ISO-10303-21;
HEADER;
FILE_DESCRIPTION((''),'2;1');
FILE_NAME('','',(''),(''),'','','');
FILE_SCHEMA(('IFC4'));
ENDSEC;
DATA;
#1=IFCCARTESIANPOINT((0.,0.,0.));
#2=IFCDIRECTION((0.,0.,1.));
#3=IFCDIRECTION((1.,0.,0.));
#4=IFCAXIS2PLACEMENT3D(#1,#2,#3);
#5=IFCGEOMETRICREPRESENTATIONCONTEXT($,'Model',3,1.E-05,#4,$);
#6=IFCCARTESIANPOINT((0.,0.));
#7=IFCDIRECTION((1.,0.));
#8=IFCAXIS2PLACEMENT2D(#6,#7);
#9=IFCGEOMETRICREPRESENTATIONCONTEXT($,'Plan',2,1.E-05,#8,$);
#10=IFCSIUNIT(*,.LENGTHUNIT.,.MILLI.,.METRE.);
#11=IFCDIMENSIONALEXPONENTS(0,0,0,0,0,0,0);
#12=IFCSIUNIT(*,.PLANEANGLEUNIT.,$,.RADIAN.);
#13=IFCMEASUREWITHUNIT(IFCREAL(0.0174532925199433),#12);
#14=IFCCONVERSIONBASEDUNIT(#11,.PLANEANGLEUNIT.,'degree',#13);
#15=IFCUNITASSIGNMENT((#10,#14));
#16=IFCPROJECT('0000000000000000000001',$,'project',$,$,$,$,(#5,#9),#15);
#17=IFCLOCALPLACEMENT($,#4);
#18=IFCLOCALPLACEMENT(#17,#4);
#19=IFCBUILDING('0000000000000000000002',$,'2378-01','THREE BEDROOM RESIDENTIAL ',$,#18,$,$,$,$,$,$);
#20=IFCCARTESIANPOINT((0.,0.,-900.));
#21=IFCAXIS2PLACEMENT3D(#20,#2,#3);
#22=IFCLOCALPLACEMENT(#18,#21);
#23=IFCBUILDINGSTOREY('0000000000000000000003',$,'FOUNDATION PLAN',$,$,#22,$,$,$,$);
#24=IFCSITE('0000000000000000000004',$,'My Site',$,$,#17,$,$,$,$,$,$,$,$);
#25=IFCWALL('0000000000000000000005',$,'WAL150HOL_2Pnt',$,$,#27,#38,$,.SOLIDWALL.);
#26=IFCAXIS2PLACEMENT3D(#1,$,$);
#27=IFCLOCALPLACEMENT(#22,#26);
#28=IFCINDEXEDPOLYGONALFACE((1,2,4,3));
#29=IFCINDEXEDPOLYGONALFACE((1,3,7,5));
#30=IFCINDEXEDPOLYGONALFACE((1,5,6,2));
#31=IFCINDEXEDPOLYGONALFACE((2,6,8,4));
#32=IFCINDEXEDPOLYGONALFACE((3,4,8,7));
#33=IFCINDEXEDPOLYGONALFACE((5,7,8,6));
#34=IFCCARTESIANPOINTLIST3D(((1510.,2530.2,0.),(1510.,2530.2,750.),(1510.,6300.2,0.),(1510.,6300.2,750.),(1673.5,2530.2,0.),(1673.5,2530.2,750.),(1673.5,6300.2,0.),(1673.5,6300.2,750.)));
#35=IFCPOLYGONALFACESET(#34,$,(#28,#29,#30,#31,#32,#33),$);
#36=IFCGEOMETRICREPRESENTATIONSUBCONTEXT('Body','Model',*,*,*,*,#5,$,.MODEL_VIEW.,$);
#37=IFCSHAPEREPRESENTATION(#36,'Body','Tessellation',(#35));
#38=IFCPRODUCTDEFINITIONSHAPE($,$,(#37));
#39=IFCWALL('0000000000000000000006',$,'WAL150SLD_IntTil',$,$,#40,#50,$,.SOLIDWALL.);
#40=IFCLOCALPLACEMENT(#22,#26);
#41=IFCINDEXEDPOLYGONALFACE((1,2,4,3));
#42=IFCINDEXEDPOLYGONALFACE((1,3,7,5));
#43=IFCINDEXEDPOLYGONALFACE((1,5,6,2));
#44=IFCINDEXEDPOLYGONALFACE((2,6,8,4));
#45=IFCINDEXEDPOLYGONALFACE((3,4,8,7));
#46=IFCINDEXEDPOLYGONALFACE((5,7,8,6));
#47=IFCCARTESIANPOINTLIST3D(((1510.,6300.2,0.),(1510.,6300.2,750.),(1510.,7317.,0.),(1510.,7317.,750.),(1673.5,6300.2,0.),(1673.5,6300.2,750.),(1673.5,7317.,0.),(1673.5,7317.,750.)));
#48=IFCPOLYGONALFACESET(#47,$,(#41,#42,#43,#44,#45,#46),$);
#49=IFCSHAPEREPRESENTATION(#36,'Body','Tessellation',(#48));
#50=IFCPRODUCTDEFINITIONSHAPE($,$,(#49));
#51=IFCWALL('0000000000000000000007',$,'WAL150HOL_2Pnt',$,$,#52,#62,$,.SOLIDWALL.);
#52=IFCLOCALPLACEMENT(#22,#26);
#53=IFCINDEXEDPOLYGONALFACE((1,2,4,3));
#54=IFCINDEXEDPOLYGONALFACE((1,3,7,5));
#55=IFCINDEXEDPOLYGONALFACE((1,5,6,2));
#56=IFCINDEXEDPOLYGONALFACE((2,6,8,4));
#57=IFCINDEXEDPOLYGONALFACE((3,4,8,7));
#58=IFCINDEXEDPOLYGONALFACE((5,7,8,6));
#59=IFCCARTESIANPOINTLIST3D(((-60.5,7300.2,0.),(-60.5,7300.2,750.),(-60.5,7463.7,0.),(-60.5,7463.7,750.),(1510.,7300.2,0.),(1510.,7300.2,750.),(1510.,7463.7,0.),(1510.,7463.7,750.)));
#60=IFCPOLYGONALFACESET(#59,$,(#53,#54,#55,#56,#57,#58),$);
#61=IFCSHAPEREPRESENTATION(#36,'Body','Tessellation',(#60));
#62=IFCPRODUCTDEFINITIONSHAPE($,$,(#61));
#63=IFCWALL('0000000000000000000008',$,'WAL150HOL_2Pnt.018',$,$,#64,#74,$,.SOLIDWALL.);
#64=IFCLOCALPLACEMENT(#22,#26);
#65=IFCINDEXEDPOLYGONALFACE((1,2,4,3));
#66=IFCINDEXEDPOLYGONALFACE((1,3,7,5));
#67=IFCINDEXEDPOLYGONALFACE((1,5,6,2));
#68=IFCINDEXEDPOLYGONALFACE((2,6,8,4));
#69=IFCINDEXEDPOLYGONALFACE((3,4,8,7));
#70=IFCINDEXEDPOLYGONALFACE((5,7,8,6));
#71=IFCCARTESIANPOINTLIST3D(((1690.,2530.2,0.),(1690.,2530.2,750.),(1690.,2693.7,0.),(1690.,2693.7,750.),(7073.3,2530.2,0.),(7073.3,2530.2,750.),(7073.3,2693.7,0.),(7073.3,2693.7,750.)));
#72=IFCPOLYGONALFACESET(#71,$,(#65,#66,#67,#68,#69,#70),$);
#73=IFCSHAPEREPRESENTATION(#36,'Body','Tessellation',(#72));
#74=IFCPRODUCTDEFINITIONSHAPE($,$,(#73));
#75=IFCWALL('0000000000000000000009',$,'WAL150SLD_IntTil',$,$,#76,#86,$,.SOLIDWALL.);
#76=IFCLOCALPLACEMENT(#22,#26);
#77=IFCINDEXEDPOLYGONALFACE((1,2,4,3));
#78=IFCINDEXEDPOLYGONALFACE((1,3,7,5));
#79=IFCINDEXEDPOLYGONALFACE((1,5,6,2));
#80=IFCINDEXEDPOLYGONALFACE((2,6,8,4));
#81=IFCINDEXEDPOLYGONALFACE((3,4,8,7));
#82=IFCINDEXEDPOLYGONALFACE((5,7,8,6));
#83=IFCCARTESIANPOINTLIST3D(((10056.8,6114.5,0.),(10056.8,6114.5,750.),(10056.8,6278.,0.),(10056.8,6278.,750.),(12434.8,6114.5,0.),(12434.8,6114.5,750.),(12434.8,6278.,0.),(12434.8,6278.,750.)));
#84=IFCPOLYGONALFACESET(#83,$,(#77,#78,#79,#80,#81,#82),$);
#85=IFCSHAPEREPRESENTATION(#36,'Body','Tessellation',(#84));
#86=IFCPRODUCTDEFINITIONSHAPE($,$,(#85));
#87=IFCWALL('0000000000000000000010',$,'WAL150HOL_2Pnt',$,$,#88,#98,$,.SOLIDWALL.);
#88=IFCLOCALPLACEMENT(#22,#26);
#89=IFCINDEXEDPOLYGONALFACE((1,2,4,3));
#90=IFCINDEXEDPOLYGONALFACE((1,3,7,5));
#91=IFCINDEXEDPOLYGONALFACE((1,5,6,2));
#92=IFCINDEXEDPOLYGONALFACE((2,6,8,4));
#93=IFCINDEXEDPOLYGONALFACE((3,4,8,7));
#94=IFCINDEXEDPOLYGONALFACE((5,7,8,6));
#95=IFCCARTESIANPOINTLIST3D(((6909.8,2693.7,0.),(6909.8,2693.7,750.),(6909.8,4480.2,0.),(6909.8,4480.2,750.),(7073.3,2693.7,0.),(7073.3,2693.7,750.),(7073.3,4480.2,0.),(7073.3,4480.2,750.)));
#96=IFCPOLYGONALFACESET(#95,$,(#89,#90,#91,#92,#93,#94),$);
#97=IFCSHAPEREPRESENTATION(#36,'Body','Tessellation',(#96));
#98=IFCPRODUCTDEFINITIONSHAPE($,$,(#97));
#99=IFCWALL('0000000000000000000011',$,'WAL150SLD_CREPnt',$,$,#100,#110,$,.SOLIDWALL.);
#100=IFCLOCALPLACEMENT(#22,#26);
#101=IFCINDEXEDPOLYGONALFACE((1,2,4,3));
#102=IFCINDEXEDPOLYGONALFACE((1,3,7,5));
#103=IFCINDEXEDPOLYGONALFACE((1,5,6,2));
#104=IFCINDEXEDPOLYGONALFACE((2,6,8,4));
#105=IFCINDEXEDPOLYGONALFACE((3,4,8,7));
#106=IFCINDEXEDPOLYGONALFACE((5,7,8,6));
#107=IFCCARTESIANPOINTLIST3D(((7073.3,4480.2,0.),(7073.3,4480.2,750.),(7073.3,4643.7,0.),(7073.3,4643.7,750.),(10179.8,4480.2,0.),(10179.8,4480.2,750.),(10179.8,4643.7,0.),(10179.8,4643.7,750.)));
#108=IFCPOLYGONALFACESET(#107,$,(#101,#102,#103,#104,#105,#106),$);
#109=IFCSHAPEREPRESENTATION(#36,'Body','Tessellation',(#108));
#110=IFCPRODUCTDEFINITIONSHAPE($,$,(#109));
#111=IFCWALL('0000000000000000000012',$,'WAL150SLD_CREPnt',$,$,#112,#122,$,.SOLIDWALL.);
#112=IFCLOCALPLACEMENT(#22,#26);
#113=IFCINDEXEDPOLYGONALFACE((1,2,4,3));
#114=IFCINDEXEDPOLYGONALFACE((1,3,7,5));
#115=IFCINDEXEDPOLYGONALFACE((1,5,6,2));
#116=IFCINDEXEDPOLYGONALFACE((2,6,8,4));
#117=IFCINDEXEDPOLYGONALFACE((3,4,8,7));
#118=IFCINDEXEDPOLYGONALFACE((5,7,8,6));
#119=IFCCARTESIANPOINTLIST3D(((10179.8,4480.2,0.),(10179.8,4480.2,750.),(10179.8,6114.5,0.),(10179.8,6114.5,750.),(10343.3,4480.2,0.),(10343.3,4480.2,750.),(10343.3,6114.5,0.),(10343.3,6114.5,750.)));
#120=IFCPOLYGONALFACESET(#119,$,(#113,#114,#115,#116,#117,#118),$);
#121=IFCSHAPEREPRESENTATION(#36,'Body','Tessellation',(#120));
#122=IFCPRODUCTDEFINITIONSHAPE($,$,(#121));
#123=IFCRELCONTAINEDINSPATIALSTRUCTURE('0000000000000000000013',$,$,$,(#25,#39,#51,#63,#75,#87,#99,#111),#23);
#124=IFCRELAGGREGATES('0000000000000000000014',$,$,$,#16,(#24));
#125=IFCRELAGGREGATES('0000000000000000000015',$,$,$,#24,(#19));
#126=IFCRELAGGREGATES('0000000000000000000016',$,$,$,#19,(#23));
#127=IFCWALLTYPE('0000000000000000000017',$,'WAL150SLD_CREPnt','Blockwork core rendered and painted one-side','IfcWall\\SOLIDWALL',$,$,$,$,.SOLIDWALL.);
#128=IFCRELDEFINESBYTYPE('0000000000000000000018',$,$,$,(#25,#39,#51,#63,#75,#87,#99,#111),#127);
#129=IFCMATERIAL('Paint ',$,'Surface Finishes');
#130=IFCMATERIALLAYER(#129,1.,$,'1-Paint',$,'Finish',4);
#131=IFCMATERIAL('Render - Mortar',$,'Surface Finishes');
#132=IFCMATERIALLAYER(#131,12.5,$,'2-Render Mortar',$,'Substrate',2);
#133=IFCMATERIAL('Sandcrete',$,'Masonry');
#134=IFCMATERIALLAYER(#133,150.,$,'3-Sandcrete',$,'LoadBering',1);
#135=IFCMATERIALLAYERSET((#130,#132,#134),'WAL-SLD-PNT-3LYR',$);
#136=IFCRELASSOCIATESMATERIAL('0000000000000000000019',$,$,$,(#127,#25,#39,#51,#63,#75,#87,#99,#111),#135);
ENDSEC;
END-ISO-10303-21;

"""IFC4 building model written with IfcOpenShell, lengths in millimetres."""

from ifc_helpers import new_model, entity, si_unit, converted_unit, frame, origin_with_axes, origin_2d_with_axis, place, context, subcontext, project, spatial, indexed_curve, outline, extrude, material, layer, layer_set, layer_usage, type_object, element, save


model = new_model("IFC4")

# Units and contexts
model_context = context("Model", 3, precision=1e-05, world=origin_with_axes())
plan_context = context("Plan", 2, precision=1e-05, world=origin_2d_with_axis())
body_context = subcontext(model_context, "Body", "Model", "MODEL_VIEW")
ifc_project = project(units=[si_unit("LENGTHUNIT", "METRE", prefix="MILLI"), converted_unit("PLANEANGLEUNIT", "degree", entity("IfcReal", 0.0174532925199433), si_unit("PLANEANGLEUNIT", "RADIAN"), dimensions=[0, 0, 0, 0, 0, 0, 0])], contexts=[model_context, plan_context])

# Site, building, storey
site_placement = place(None, origin_with_axes())
site = spatial("IfcSite", under=ifc_project, at=site_placement, Name="My Site")
building_placement = place(site_placement, origin_with_axes())
building = spatial("IfcBuilding", under=site, at=building_placement, Name="2378-01", Description="THREE BEDROOM RESIDENTIAL ")
storey_placement = place(building_placement, frame((0.0, 0.0, -900.0), z_axis=(0.0, 0.0, 1.0), x_axis=(1.0, 0.0, 0.0)))
storey = spatial("IfcBuildingStorey", under=building, at=storey_placement, Name="FOUNDATION PLAN")

# Walls
ifc_material_1 = material(Name="Sandcrete", Category="Masonry")
ifc_material_2 = material(Name="Paint ", Category="Surface Finishes")
ifc_layer_1 = layer(ifc_material_2, 1.0, Name="1-Paint", Category="Finish", Priority=4)
ifc_material_3 = material(Name="Render - Mortar", Category="Surface Finishes")
ifc_layer_2 = layer(ifc_material_3, 12.5, Name="2-Render Mortar", Category="Substrate", Priority=2)
ifc_layer_3 = layer(ifc_material_1, 150.0, Name="3-Sandcrete", Category="LoadBering", Priority=1)
ifc_layer_set_1 = layer_set([ifc_layer_1, ifc_layer_2, ifc_layer_3], Name="WAL-SLD-PNT-3LYR")
wall_type_1 = type_object("IfcWallType", Name="WAL150SLD_CREPnt", Description="Blockwork core rendered and painted one-side", ApplicableOccurrence="IfcWall\\SOLIDWALL", PredefinedType="SOLIDWALL", material=ifc_layer_set_1)
ifc_layer_usage_1 = layer_usage(ifc_layer_set_1, "AXIS2", "POSITIVE", 0.0)
wall_1_placement = place(storey_placement, frame((1510.0, 6300.2, 0.0), z_axis=(0.0, 0.0, 1.0), x_axis=(-0.000001, -1.0, 0.0)))
element("IfcWall", 1, at=wall_1_placement, inside=storey, type_object=wall_type_1, material=ifc_layer_usage_1, Name="WAL150HOL_2Pnt", PredefinedType="SOLIDWALL", context=body_context, shape_type="SweptSolid", body=[
    extrude(outline(indexed_curve([(0.0, 0.0), (0.0, 163.5), (3770.0, 163.5), (3770.0, 0.0), (0.0, 0.0)], self_intersect=False)), origin_with_axes(), (0.0, 0.0, 1.0), 750.0),
])
ifc_layer_usage_2 = layer_usage(ifc_layer_set_1, "AXIS2", "POSITIVE", 0.0)
wall_2_placement = place(storey_placement, frame((1510.0, 7317.0, 0.0), z_axis=(0.0, 0.0, 1.0), x_axis=(-0.000001, -1.0, 0.0)))
element("IfcWall", 2, at=wall_2_placement, inside=storey, type_object=wall_type_1, material=ifc_layer_usage_2, Name="WAL150SLD_IntTil", PredefinedType="SOLIDWALL", context=body_context, shape_type="SweptSolid", body=[
    extrude(outline(indexed_curve([(0.0, 0.0), (0.0, 163.5), (1016.8, 163.5), (1016.8, 0.0), (0.0, 0.0)], self_intersect=False)), origin_with_axes(), (0.0, 0.0, 1.0), 750.0),
])
ifc_layer_usage_3 = layer_usage(ifc_layer_set_1, "AXIS2", "POSITIVE", 0.0)
wall_3_placement = place(storey_placement, frame((-60.5, 7300.2, 0.0), z_axis=(0.0, 0.0, 1.0), x_axis=(1.0, 0.0, 0.0)))
element("IfcWall", 3, at=wall_3_placement, inside=storey, type_object=wall_type_1, material=ifc_layer_usage_3, Name="WAL150HOL_2Pnt", PredefinedType="SOLIDWALL", context=body_context, shape_type="SweptSolid", body=[
    extrude(outline(indexed_curve([(0.0, 0.0), (0.0, 163.5), (1570.5, 163.5), (1570.5, 0.0), (0.0, 0.0)], self_intersect=False)), origin_with_axes(), (0.0, 0.0, 1.0), 750.0),
])
ifc_layer_usage_4 = layer_usage(ifc_layer_set_1, "AXIS2", "POSITIVE", 0.0)
wall_4_placement = place(storey_placement, frame((1690.0, 2530.2, 0.0), z_axis=(0.0, 0.0, 1.0), x_axis=(1.0, 0.0, 0.0)))
element("IfcWall", 4, at=wall_4_placement, inside=storey, type_object=wall_type_1, material=ifc_layer_usage_4, Name="WAL150HOL_2Pnt.018", PredefinedType="SOLIDWALL", context=body_context, shape_type="SweptSolid", body=[
    extrude(outline(indexed_curve([(0.0, 0.0), (0.0, 163.5), (5383.3, 163.5), (5383.3, 0.0), (0.0, 0.0)], self_intersect=False)), origin_with_axes(), (0.0, 0.0, 1.0), 750.0),
])
ifc_layer_usage_5 = layer_usage(ifc_layer_set_1, "AXIS2", "POSITIVE", 0.0)
wall_5_placement = place(storey_placement, frame((10056.8, 6114.5, 0.0), z_axis=(0.0, 0.0, 1.0), x_axis=(1.0, 0.0, 0.0)))
element("IfcWall", 5, at=wall_5_placement, inside=storey, type_object=wall_type_1, material=ifc_layer_usage_5, Name="WAL150SLD_IntTil", PredefinedType="SOLIDWALL", context=body_context, shape_type="SweptSolid", body=[
    extrude(outline(indexed_curve([(0.0, 0.0), (0.0, 163.5), (2378.0, 163.5), (2378.0, 0.0), (0.0, 0.0)], self_intersect=False)), origin_with_axes(), (0.0, 0.0, 1.0), 750.0),
])
ifc_layer_usage_6 = layer_usage(ifc_layer_set_1, "AXIS2", "POSITIVE", 0.0)
wall_6_placement = place(storey_placement, frame((7073.3, 2693.7, 0.0), z_axis=(0.0, 0.0, 1.0), x_axis=(0.000002, 1.0, 0.0)))
element("IfcWall", 6, at=wall_6_placement, inside=storey, type_object=wall_type_1, material=ifc_layer_usage_6, Name="WAL150HOL_2Pnt", PredefinedType="SOLIDWALL", context=body_context, shape_type="SweptSolid", body=[
    extrude(outline(indexed_curve([(0.0, 0.0), (0.0, 163.5), (1786.5, 163.5), (1786.5, 0.0), (0.0, 0.0)], self_intersect=False)), origin_with_axes(), (0.0, 0.0, 1.0), 750.0),
])
ifc_layer_usage_7 = layer_usage(ifc_layer_set_1, "AXIS2", "POSITIVE", 0.0)
wall_7_placement = place(storey_placement, frame((7073.3, 4480.2, 0.0), z_axis=(0.0, 0.0, 1.0), x_axis=(1.0, 0.0, 0.0)))
element("IfcWall", 7, at=wall_7_placement, inside=storey, type_object=wall_type_1, material=ifc_layer_usage_7, Name="WAL150SLD_CREPnt", PredefinedType="SOLIDWALL", context=body_context, shape_type="SweptSolid", body=[
    extrude(outline(indexed_curve([(0.0, 0.0), (0.0, 163.5), (3106.5, 163.5), (3106.5, 0.0), (0.0, 0.0)], self_intersect=False)), origin_with_axes(), (0.0, 0.0, 1.0), 750.0),
])
ifc_layer_usage_8 = layer_usage(ifc_layer_set_1, "AXIS2", "POSITIVE", 0.0)
wall_8_placement = place(storey_placement, frame((10343.3, 4480.2, 0.0), z_axis=(0.0, 0.0, 1.0), x_axis=(0.000002, 1.0, 0.0)))
element("IfcWall", 8, at=wall_8_placement, inside=storey, type_object=wall_type_1, material=ifc_layer_usage_8, Name="WAL150SLD_CREPnt", PredefinedType="SOLIDWALL", context=body_context, shape_type="SweptSolid", body=[
    extrude(outline(indexed_curve([(0.0, 0.0), (0.0, 163.5), (1634.3, 163.5), (1634.3, 0.0), (0.0, 0.0)], self_intersect=False)), origin_with_axes(), (0.0, 0.0, 1.0), 750.0),
])

save(model, "model.ifc")
